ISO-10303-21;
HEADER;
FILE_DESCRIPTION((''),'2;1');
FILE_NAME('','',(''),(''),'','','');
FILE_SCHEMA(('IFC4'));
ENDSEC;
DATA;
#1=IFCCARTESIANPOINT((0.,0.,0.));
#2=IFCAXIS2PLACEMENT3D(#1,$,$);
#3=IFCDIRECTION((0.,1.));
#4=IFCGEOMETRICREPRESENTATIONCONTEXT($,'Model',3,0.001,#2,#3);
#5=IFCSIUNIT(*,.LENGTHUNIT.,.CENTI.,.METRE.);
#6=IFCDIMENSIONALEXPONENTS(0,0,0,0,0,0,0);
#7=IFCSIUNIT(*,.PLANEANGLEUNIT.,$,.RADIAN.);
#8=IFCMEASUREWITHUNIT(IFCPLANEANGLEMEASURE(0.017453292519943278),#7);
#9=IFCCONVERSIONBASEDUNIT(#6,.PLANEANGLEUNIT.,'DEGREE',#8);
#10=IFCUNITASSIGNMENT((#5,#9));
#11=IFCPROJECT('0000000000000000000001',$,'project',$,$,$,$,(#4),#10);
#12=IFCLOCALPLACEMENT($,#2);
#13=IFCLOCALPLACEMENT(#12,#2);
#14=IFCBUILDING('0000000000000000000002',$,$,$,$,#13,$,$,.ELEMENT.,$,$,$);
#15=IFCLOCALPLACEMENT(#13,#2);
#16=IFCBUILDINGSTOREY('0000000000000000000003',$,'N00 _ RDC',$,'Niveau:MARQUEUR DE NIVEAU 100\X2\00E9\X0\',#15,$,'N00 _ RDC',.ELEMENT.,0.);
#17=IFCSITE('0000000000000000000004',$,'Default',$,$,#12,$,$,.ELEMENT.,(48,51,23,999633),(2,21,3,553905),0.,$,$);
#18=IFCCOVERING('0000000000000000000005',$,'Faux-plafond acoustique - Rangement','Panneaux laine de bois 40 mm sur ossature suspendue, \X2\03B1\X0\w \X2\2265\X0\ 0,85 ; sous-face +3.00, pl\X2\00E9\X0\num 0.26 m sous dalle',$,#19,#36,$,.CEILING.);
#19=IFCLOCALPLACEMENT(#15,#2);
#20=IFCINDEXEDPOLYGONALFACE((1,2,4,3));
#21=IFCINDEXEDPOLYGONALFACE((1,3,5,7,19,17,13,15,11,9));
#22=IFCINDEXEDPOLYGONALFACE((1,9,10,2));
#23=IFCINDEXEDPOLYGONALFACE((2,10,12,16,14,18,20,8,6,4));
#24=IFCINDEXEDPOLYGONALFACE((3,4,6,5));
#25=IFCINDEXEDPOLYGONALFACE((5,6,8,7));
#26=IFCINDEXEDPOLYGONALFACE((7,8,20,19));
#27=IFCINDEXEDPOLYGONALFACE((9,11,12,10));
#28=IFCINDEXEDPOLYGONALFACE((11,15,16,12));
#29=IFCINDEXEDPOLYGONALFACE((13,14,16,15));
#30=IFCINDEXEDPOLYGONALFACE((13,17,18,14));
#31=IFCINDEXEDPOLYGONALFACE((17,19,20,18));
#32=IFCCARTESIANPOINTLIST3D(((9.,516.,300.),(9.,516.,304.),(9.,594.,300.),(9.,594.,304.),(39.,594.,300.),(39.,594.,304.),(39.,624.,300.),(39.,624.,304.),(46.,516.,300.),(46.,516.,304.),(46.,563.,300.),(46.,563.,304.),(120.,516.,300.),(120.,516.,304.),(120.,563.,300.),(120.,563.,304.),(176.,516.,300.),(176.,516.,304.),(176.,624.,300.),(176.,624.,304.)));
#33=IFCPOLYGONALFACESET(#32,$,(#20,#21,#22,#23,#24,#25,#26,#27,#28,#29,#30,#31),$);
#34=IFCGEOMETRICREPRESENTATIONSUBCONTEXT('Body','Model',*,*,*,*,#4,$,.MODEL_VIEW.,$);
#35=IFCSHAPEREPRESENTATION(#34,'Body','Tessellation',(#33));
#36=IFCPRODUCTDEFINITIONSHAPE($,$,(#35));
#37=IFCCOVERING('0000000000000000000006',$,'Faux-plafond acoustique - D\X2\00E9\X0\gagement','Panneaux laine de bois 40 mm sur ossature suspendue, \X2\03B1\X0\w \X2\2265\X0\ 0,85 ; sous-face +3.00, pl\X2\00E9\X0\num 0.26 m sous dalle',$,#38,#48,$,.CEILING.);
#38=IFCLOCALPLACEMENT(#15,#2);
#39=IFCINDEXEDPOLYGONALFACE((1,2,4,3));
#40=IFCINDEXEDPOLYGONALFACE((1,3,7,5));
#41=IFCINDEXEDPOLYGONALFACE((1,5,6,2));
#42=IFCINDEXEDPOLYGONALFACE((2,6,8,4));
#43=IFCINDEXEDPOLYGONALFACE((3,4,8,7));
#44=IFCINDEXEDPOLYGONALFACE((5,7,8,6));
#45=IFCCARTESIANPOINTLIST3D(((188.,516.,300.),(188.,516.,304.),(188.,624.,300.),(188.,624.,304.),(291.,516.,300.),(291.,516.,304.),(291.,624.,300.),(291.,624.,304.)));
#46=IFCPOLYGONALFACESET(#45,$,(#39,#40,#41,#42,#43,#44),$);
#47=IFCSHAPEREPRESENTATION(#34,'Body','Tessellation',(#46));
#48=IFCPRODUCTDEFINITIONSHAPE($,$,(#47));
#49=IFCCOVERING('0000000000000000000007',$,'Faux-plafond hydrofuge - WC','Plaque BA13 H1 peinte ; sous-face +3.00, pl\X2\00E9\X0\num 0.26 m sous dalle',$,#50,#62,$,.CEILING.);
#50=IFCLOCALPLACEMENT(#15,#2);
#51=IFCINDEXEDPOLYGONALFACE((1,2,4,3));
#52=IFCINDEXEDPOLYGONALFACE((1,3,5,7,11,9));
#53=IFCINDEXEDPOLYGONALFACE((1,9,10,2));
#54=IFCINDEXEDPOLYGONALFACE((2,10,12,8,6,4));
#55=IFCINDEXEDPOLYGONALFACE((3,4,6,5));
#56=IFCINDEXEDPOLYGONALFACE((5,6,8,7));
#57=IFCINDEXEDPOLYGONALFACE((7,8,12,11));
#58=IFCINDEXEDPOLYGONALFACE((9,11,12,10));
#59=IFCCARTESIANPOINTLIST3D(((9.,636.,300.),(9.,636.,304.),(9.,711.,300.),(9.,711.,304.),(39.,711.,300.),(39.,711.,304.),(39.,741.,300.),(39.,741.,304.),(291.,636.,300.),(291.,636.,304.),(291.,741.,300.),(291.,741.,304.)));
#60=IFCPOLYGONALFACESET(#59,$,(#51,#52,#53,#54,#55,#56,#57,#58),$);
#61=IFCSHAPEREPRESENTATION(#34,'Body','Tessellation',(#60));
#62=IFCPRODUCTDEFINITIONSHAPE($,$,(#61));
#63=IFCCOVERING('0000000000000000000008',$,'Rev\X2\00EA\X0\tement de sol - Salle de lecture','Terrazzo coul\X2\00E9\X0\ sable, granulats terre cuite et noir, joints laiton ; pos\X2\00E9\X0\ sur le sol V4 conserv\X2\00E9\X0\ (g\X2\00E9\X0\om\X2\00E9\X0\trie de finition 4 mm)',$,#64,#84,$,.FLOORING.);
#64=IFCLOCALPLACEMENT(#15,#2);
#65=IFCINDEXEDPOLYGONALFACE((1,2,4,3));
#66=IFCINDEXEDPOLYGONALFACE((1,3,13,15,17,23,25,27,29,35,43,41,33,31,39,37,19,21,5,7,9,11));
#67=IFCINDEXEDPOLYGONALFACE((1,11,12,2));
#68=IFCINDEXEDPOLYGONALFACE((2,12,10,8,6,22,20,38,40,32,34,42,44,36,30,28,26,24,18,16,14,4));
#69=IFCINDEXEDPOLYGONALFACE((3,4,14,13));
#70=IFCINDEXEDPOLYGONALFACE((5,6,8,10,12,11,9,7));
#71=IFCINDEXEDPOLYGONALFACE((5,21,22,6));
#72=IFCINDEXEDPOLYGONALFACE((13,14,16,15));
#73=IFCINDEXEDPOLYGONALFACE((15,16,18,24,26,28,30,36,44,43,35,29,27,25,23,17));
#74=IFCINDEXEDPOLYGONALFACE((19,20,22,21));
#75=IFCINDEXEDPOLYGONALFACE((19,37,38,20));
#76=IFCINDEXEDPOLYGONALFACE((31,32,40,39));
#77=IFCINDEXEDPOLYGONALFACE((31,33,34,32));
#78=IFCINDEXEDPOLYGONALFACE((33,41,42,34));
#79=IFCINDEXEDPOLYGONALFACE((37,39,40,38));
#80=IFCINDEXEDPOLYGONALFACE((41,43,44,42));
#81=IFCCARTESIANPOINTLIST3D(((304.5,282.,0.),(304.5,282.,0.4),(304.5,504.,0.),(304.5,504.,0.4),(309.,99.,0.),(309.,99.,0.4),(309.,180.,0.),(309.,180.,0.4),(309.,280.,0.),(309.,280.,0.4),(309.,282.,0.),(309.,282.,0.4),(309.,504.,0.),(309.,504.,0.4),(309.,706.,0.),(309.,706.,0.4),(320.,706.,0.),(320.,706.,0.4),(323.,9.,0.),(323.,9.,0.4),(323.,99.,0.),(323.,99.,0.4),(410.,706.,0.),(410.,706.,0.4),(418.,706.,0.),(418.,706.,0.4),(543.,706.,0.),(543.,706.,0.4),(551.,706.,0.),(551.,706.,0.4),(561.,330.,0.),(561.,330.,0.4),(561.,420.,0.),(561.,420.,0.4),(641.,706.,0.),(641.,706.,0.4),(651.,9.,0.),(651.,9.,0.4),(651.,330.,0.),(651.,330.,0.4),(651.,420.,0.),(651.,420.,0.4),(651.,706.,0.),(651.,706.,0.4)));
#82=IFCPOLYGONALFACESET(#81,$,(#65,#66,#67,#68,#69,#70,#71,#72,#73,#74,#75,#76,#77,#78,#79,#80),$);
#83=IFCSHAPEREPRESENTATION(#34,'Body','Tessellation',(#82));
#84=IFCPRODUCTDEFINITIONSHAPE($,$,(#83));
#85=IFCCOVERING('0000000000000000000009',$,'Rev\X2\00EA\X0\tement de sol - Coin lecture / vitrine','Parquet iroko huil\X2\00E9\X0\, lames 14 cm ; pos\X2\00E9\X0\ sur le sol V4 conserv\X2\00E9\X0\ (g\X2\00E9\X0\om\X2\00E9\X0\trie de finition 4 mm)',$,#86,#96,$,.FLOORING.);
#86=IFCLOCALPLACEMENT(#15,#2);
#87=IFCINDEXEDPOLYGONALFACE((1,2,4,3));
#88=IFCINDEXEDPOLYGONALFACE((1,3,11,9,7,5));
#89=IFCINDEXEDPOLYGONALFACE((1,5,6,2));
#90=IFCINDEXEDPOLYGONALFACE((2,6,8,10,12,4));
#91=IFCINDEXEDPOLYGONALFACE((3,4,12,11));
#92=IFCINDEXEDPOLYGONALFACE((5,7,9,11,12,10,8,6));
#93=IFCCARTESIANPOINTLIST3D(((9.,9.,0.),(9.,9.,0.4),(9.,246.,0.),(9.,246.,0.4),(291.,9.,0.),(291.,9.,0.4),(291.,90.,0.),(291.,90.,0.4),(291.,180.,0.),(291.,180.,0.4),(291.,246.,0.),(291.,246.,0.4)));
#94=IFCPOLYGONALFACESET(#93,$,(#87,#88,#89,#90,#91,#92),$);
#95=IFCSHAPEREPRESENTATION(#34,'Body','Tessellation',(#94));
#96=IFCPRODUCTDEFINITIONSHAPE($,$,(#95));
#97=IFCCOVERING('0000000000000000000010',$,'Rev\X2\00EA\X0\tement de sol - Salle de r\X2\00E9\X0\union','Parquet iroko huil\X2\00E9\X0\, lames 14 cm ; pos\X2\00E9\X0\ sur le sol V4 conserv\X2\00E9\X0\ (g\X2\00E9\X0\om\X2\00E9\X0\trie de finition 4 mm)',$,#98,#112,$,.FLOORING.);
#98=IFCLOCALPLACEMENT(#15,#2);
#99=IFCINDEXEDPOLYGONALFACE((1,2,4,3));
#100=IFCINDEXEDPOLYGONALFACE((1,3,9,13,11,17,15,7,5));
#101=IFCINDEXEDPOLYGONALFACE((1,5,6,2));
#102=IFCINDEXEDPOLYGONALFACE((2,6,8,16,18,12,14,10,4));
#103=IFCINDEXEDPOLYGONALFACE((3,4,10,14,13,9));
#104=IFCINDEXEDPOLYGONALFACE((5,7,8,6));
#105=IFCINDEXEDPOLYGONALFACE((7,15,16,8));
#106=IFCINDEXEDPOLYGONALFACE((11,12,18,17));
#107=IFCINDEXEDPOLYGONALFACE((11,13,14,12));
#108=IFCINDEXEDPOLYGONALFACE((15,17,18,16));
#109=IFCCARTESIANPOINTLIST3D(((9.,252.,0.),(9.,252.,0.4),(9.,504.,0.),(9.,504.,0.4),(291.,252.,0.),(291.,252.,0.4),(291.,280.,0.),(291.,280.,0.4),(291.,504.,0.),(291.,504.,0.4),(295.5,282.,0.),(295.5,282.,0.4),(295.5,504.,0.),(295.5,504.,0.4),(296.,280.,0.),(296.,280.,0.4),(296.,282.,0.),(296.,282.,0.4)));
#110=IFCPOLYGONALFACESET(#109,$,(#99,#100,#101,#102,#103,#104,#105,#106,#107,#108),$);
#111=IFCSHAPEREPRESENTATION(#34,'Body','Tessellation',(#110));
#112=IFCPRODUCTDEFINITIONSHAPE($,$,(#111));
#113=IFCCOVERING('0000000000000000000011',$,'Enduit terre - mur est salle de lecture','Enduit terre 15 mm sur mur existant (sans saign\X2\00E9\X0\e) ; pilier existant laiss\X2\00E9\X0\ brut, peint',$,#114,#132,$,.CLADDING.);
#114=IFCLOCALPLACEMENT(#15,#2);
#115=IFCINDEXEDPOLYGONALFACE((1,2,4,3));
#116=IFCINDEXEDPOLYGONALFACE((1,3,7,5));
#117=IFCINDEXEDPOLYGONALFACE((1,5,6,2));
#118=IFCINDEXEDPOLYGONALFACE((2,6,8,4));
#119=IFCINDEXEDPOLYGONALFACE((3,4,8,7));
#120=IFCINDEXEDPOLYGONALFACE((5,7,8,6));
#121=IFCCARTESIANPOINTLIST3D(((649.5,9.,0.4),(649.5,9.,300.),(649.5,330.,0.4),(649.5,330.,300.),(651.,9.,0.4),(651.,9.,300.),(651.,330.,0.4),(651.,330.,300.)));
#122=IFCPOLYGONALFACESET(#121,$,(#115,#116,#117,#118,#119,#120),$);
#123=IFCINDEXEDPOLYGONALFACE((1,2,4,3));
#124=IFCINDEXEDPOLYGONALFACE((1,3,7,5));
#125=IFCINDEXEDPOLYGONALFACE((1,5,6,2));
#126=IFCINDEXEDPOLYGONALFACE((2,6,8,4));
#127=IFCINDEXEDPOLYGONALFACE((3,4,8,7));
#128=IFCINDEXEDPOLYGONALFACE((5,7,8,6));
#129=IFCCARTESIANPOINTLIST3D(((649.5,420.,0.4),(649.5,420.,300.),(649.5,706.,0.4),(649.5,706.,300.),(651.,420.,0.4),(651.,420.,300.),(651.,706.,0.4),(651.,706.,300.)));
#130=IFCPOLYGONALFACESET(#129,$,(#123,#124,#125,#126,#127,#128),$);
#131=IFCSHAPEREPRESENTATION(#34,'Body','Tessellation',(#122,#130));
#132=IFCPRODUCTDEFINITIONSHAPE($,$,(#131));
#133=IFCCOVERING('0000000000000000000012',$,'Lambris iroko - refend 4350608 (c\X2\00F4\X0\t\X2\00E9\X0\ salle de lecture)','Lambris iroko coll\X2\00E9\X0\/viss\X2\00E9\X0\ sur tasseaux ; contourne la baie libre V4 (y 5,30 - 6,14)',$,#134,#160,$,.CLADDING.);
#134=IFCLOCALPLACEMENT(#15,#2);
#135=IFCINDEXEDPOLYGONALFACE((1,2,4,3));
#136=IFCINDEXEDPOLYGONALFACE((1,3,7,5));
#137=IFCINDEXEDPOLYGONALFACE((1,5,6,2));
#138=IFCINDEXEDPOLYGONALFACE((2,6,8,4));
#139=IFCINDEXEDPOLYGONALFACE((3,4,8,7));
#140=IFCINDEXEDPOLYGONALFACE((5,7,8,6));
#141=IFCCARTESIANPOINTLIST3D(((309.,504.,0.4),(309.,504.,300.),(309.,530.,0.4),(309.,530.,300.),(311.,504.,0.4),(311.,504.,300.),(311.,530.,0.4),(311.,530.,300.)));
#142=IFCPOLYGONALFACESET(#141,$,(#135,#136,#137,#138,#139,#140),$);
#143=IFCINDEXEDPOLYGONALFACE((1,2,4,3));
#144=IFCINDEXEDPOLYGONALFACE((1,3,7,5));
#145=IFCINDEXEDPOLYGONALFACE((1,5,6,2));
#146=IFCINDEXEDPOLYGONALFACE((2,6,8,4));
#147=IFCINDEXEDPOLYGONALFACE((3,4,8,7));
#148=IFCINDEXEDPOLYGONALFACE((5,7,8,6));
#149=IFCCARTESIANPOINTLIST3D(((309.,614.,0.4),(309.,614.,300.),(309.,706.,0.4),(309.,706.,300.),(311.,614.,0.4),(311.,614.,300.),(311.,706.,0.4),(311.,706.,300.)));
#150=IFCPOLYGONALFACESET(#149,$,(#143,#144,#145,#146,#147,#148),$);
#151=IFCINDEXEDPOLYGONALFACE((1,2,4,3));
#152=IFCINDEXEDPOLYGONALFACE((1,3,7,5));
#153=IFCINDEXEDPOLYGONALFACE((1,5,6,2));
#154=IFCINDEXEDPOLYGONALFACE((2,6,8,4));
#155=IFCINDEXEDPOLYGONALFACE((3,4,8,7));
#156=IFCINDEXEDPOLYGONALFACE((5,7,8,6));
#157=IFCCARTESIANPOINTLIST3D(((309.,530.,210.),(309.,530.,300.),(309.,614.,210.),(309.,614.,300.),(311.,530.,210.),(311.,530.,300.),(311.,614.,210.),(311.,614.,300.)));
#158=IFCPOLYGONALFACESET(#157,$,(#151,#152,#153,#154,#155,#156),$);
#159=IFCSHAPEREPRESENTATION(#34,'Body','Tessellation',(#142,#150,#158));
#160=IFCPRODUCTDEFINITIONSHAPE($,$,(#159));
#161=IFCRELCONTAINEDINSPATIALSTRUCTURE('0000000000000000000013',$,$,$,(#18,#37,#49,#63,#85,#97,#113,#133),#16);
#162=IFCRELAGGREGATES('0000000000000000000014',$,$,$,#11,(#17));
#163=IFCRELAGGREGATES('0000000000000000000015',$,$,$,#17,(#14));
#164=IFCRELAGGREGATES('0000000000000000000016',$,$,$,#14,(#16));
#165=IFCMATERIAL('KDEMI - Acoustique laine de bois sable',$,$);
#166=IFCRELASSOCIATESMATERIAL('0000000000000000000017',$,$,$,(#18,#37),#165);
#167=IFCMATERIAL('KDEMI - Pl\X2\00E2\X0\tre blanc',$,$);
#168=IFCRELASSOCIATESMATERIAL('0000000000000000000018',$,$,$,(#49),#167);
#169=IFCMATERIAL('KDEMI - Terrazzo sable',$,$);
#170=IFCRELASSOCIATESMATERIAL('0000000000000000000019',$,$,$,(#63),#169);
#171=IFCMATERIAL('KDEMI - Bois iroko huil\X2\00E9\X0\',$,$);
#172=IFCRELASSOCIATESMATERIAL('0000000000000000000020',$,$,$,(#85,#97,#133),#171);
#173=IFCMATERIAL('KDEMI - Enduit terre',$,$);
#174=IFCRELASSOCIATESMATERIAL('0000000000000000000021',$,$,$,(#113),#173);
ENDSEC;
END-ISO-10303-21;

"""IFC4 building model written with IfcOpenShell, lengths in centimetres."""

from ifc_helpers import new_model, entity, si_unit, converted_unit, direction, frame, frame_2d, origin, origin_with_axes, place, context, subcontext, project, spatial, polyline, rectangle, outline, extrude, material, element, save


model = new_model("IFC4")

# Units and contexts
model_context = context("Model", 3, precision=0.001, world=origin(), true_north=direction((0.0, 1.0)))
body_context = subcontext(model_context, "Body", "Model", "MODEL_VIEW")
ifc_project = project(units=[si_unit("LENGTHUNIT", "METRE", prefix="CENTI"), converted_unit("PLANEANGLEUNIT", "DEGREE", entity("IfcPlaneAngleMeasure", 0.017453292519943278), si_unit("PLANEANGLEUNIT", "RADIAN"), dimensions=[0, 0, 0, 0, 0, 0, 0])], contexts=[model_context])

# Site, building, storey
site_placement = place(None, origin())
site = spatial("IfcSite", under=ifc_project, at=site_placement, Name="Default", CompositionType="ELEMENT", RefLatitude=(48, 51, 23, 999633), RefLongitude=(2, 21, 3, 553905), RefElevation=0.0)
building_placement = place(site_placement, origin())
building = spatial("IfcBuilding", under=site, at=building_placement, CompositionType="ELEMENT")
storey_placement = place(building_placement, origin())
storey = spatial("IfcBuildingStorey", under=building, at=storey_placement, Name="N00 _ RDC", ObjectType="Niveau:MARQUEUR DE NIVEAU 100é", LongName="N00 _ RDC", CompositionType="ELEMENT", Elevation=0.0)

# Coverings
ifc_material_1 = material(Name="KDEMI - Acoustique laine de bois sable")
covering_1_placement = place(storey_placement, origin_with_axes())
element("IfcCovering", 1, at=covering_1_placement, inside=storey, material=ifc_material_1, Name="Faux-plafond acoustique - Rangement", Description="Panneaux laine de bois 40 mm sur ossature suspendue, αw ≥ 0,85 ; sous-face +3.00, plénum 0.26 m sous dalle", PredefinedType="CEILING", context=body_context, shape_type="SweptSolid", body=[
    extrude(outline(polyline([(120.0, 563.0), (46.0, 563.0), (46.0, 516.0), (9.0, 516.0), (9.0, 594.0), (39.0, 594.0), (39.0, 624.0), (176.0, 624.0), (176.0, 516.0), (120.0, 516.0), (120.0, 563.0)])), frame((0.0, 0.0, 300.0)), (0.0, 0.0, 1.0), 4.0),
])
covering_2_placement = place(storey_placement, origin_with_axes())
element("IfcCovering", 2, at=covering_2_placement, inside=storey, material=ifc_material_1, Name="Faux-plafond acoustique - Dégagement", Description="Panneaux laine de bois 40 mm sur ossature suspendue, αw ≥ 0,85 ; sous-face +3.00, plénum 0.26 m sous dalle", PredefinedType="CEILING", context=body_context, shape_type="SweptSolid", body=[
    extrude(outline(polyline([(291.0, 516.0), (188.0, 516.0), (188.0, 624.0), (291.0, 624.0), (291.0, 516.0)])), frame((0.0, 0.0, 300.0)), (0.0, 0.0, 1.0), 4.0),
])
ifc_material_2 = material(Name="KDEMI - Plâtre blanc")
covering_3_placement = place(storey_placement, origin_with_axes())
element("IfcCovering", 3, at=covering_3_placement, inside=storey, material=ifc_material_2, Name="Faux-plafond hydrofuge - WC", Description="Plaque BA13 H1 peinte ; sous-face +3.00, plénum 0.26 m sous dalle", PredefinedType="CEILING", context=body_context, shape_type="SweptSolid", body=[
    extrude(outline(polyline([(9.0, 636.0), (9.0, 711.0), (39.0, 711.0), (39.0, 741.0), (291.0, 741.0), (291.0, 636.0), (9.0, 636.0)])), frame((0.0, 0.0, 300.0)), (0.0, 0.0, 1.0), 4.0),
])
ifc_material_3 = material(Name="KDEMI - Terrazzo sable")
covering_4_placement = place(storey_placement, origin_with_axes())
element("IfcCovering", 4, at=covering_4_placement, inside=storey, material=ifc_material_3, Name="Revêtement de sol - Salle de lecture", Description="Terrazzo coulé sable, granulats terre cuite et noir, joints laiton ; posé sur le sol V4 conservé (géométrie de finition 4 mm)", PredefinedType="FLOORING", context=body_context, shape_type="SweptSolid", body=[
    extrude(outline(polyline([(418.0, 706.0), (543.0, 706.0), (551.0, 706.0), (641.0, 706.0), (651.0, 706.0), (651.0, 420.0), (561.0, 420.0), (561.0, 330.0), (651.0, 330.0), (651.0, 9.0), (651.0, 9.0), (651.0, 9.0), (323.0, 9.0), (323.0, 99.0), (309.0, 99.0), (309.0, 180.0), (309.0, 180.0), (309.0, 280.0), (309.0, 280.0), (309.0, 282.0), (304.0, 282.0), (304.0, 282.0), (304.5, 282.0), (304.5, 504.0), (309.0, 504.0), (309.0, 504.0), (309.0, 706.0), (320.0, 706.0), (410.0, 706.0), (418.0, 706.0)])), origin(), (0.0, 0.0, 1.0), 0.4),
])
ifc_material_4 = material(Name="KDEMI - Bois iroko huilé")
covering_5_placement = place(storey_placement, origin_with_axes())
element("IfcCovering", 5, at=covering_5_placement, inside=storey, material=ifc_material_4, Name="Revêtement de sol - Coin lecture / vitrine", Description="Parquet iroko huilé, lames 14 cm ; posé sur le sol V4 conservé (géométrie de finition 4 mm)", PredefinedType="FLOORING", context=body_context, shape_type="SweptSolid", body=[
    extrude(outline(polyline([(291.0, 90.0), (291.0, 90.0), (291.0, 9.0), (9.0, 9.0), (9.0, 246.0), (291.0, 246.0), (291.0, 180.0), (291.0, 180.0), (291.0, 90.0)])), origin(), (0.0, 0.0, 1.0), 0.4),
])
covering_6_placement = place(storey_placement, origin_with_axes())
element("IfcCovering", 6, at=covering_6_placement, inside=storey, material=ifc_material_4, Name="Revêtement de sol - Salle de réunion", Description="Parquet iroko huilé, lames 14 cm ; posé sur le sol V4 conservé (géométrie de finition 4 mm)", PredefinedType="FLOORING", context=body_context, shape_type="SweptSolid", body=[
    extrude(outline(polyline([(296.0, 280.0), (291.0, 280.0), (291.0, 252.0), (9.0, 252.0), (9.0, 504.0), (291.0, 504.0), (295.5, 504.0), (295.5, 282.0), (296.0, 282.0), (296.0, 280.0)])), origin(), (0.0, 0.0, 1.0), 0.4),
])
ifc_material_5 = material(Name="KDEMI - Enduit terre")
covering_7_placement = place(storey_placement, origin_with_axes())
element("IfcCovering", 7, at=covering_7_placement, inside=storey, material=ifc_material_5, Name="Enduit terre - mur est salle de lecture", Description="Enduit terre 15 mm sur mur existant (sans saignée) ; pilier existant laissé brut, peint", PredefinedType="CLADDING", context=body_context, shape_type="SweptSolid", body=[
    extrude(rectangle(XDim=1.5, YDim=321.0, at=frame_2d((650.25, 169.5))), frame((0.0, 0.0, 0.4)), (0.0, 0.0, 1.0), 299.6),
    extrude(rectangle(XDim=1.5, YDim=286.0, at=frame_2d((650.25, 563.0))), frame((0.0, 0.0, 0.4)), (0.0, 0.0, 1.0), 299.6),
])
covering_8_placement = place(storey_placement, origin_with_axes())
element("IfcCovering", 8, at=covering_8_placement, inside=storey, material=ifc_material_4, Name="Lambris iroko - refend 4350608 (côté salle de lecture)", Description="Lambris iroko collé/vissé sur tasseaux ; contourne la baie libre V4 (y 5,30 - 6,14)", PredefinedType="CLADDING", context=body_context, shape_type="SweptSolid", body=[
    extrude(rectangle(XDim=2.0, YDim=26.0, at=frame_2d((310.0, 517.0))), frame((0.0, 0.0, 0.4)), (0.0, 0.0, 1.0), 299.6),
    extrude(rectangle(XDim=2.0, YDim=92.0, at=frame_2d((310.0, 660.0))), frame((0.0, 0.0, 0.4)), (0.0, 0.0, 1.0), 299.6),
    extrude(rectangle(XDim=2.0, YDim=84.0, at=frame_2d((310.0, 572.0))), frame((0.0, 0.0, 210.0)), (0.0, 0.0, 1.0), 90.0),
])

save(model, "model.ifc")
